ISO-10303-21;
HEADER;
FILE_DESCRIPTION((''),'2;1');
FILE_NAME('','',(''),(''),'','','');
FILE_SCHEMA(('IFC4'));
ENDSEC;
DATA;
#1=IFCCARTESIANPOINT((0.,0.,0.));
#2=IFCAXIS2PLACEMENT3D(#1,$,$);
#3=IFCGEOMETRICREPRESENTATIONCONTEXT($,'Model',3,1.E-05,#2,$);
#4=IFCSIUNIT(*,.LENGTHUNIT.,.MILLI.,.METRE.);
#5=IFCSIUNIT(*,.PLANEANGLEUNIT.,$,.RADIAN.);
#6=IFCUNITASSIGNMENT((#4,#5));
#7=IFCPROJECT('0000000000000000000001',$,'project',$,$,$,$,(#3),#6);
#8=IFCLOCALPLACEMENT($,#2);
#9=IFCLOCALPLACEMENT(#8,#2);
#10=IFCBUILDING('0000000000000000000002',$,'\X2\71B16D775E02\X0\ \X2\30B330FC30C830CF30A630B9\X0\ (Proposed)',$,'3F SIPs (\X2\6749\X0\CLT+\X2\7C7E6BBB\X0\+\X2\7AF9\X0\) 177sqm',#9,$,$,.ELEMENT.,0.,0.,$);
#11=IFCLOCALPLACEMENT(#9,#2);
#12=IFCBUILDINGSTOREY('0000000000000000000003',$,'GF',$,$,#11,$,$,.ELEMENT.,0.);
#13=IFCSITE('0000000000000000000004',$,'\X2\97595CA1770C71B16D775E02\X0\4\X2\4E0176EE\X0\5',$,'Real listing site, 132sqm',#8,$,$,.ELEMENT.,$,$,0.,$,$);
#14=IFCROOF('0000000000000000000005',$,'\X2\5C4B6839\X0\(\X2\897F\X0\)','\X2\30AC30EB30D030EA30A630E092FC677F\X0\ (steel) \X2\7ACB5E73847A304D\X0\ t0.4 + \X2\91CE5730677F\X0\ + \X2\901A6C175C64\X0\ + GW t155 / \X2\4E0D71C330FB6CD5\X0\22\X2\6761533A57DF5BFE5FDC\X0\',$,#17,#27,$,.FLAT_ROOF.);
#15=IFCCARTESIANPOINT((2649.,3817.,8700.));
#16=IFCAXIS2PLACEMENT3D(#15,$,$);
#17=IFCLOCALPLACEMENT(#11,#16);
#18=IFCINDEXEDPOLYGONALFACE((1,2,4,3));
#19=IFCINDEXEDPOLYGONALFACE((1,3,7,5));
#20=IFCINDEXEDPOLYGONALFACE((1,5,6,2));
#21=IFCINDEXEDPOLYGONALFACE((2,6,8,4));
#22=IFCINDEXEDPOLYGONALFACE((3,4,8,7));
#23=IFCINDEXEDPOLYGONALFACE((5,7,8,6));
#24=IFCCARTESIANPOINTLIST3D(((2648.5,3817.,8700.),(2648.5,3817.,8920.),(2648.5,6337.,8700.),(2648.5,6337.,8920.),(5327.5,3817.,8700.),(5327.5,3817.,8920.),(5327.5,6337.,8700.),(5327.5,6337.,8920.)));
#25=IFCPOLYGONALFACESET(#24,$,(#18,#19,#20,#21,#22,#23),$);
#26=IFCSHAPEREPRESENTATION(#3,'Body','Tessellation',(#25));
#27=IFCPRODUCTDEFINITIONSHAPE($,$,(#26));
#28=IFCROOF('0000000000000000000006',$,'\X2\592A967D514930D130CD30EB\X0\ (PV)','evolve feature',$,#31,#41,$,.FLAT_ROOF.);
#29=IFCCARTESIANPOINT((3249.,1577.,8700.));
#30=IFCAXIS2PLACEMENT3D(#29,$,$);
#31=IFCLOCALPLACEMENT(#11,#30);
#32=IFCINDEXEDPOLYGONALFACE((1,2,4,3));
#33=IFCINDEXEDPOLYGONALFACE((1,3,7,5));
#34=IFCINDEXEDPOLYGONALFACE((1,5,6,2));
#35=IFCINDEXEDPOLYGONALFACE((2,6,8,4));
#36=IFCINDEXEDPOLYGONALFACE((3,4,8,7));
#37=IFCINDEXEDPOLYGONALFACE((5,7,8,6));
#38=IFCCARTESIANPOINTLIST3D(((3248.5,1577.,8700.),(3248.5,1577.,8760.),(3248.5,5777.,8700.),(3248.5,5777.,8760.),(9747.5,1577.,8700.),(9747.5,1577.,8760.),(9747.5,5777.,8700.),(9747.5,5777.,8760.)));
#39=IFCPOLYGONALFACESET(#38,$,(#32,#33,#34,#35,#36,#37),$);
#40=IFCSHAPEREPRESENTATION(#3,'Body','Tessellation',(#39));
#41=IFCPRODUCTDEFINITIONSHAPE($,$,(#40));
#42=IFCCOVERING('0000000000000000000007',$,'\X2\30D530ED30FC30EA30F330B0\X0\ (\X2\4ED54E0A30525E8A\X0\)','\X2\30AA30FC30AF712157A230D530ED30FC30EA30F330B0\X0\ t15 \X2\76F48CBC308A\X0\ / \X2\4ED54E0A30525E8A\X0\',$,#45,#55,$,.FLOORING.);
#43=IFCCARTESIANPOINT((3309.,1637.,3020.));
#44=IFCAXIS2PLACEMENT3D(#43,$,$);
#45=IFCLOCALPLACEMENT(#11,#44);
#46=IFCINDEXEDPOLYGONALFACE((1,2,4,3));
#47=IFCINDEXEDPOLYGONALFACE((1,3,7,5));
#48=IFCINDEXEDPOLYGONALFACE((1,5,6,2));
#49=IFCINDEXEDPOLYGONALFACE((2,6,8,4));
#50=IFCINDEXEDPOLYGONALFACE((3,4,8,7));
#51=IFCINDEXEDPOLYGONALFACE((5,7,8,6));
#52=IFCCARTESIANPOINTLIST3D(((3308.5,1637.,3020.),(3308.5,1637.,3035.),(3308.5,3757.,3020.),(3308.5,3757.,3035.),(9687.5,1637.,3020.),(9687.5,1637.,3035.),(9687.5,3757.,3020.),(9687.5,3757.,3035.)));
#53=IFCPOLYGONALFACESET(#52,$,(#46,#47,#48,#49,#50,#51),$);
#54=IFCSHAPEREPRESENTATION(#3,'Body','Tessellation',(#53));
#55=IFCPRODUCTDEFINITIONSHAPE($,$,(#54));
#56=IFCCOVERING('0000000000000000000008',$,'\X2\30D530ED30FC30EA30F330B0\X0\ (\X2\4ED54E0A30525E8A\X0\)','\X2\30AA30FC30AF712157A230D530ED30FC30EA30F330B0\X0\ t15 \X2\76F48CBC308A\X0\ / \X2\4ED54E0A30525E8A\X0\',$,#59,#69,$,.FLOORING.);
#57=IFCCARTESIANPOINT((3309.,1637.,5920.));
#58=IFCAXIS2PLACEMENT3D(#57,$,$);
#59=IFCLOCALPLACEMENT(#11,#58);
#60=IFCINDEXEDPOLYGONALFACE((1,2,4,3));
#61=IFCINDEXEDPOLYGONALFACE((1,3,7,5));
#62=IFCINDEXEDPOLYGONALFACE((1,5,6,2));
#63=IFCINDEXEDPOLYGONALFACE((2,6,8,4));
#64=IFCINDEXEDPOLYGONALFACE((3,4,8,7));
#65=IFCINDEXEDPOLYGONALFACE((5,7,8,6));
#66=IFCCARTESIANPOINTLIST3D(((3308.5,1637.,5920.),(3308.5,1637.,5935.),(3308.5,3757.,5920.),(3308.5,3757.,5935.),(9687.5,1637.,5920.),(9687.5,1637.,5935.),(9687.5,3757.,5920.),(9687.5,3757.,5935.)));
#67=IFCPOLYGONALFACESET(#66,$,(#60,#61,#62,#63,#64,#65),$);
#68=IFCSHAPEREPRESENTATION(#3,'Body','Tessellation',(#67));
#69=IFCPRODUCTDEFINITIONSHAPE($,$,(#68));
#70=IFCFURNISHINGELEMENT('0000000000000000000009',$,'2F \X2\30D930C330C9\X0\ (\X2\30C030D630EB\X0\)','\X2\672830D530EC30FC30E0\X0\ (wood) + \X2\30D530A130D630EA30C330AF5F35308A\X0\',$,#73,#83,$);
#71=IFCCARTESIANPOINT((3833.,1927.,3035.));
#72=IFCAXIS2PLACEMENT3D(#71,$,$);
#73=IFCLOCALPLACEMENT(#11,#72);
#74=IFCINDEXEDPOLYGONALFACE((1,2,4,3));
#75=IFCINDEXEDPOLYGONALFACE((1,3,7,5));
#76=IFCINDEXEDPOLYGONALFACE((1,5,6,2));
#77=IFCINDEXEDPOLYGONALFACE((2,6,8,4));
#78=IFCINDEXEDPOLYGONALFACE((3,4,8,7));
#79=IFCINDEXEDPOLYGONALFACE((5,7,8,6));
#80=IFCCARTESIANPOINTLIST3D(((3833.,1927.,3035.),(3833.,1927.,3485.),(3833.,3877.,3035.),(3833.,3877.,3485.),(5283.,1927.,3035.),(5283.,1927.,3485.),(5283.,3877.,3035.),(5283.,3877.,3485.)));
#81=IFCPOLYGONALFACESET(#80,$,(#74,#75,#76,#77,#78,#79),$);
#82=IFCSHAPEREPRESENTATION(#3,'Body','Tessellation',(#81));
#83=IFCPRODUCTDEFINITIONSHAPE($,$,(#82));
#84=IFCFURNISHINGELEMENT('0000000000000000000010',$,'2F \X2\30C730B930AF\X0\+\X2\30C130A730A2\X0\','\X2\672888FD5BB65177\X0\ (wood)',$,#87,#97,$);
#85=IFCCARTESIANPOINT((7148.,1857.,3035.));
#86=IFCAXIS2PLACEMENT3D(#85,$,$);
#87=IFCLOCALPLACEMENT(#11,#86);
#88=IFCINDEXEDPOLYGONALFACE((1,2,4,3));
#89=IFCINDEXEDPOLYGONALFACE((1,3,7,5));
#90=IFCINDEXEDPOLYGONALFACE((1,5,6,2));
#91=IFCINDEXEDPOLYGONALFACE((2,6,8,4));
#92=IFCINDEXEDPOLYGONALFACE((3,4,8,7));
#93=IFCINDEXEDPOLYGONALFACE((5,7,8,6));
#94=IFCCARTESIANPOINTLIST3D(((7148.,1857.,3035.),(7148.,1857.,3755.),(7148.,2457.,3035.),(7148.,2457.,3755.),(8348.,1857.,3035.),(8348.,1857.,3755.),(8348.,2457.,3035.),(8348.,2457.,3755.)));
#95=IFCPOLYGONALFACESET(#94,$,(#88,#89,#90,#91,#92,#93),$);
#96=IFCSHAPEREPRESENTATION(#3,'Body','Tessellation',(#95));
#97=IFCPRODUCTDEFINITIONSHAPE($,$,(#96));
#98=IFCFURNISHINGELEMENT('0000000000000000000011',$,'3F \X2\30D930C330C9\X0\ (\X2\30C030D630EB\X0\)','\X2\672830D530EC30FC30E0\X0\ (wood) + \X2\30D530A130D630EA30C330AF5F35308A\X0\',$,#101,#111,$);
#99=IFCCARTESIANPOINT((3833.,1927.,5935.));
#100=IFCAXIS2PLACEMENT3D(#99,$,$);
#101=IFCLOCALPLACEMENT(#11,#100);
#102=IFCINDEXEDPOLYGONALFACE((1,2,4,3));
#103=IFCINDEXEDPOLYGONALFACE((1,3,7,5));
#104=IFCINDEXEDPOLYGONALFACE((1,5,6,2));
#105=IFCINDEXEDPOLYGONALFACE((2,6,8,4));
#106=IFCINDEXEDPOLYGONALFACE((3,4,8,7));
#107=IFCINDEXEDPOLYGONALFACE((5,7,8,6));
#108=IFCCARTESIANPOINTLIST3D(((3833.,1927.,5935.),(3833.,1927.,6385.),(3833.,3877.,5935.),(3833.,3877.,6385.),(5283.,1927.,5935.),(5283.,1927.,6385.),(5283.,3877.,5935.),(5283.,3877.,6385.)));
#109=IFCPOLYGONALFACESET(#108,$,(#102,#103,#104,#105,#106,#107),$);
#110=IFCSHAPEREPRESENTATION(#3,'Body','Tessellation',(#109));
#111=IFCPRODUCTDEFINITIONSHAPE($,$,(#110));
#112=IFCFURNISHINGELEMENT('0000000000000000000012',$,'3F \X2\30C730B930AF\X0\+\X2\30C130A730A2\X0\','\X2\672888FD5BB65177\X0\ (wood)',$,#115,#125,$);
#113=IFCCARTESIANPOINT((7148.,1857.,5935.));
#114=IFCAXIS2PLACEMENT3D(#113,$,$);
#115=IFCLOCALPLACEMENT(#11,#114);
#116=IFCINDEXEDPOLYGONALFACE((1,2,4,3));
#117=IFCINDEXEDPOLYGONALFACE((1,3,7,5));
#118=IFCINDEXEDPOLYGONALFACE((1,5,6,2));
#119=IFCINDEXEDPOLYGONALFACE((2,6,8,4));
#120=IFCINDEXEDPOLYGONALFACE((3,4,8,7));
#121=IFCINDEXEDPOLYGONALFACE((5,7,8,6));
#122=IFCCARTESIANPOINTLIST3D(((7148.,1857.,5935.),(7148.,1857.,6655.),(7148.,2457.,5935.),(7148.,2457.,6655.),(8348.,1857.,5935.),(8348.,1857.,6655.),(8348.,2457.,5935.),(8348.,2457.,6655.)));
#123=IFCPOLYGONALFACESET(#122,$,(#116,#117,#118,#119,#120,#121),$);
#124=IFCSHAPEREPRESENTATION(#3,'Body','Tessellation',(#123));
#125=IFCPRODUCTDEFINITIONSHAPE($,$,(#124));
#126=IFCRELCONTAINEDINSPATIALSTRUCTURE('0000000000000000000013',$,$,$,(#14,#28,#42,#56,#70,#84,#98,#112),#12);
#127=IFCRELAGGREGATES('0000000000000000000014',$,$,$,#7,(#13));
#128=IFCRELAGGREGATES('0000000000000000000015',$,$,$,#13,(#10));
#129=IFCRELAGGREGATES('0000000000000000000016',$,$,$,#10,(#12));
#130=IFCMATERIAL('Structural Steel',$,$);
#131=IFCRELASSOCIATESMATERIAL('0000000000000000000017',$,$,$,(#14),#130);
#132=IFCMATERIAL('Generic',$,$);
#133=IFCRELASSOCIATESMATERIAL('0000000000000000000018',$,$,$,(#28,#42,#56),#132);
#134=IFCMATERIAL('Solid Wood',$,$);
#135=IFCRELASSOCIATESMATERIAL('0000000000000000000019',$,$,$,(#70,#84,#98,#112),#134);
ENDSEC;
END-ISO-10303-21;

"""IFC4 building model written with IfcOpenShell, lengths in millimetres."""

from ifc_helpers import new_model, si_unit, frame, frame_2d, origin, place, context, project, spatial, rectangle, extrude, material, element, save


model = new_model("IFC4")

# Units and contexts
model_context = context("Model", 3, precision=1e-05, world=origin())
ifc_project = project(units=[si_unit("LENGTHUNIT", "METRE", prefix="MILLI"), si_unit("PLANEANGLEUNIT", "RADIAN")], contexts=[model_context])

# Site, building, storey
site_placement = place(None, origin())
site = spatial("IfcSite", under=ifc_project, at=site_placement, Name="静岡県熱海市4丁目5", ObjectType="Real listing site, 132sqm", CompositionType="ELEMENT", RefElevation=0.0)
building_placement = place(site_placement, origin())
building = spatial("IfcBuilding", under=site, at=building_placement, Name="熱海市 コートハウス (Proposed)", ObjectType="3F SIPs (杉CLT+籾殻+竹) 177sqm", CompositionType="ELEMENT", ElevationOfRefHeight=0.0, ElevationOfTerrain=0.0)
storey_placement = place(building_placement, origin())
storey = spatial("IfcBuildingStorey", under=building, at=storey_placement, Name="GF", CompositionType="ELEMENT", Elevation=0.0)

# Shared definitions
ifc_material_1 = material(Name="Solid Wood")

# Roofs
ifc_material_2 = material(Name="Structural Steel")
roof_1_placement = place(storey_placement, frame((2649.0, 3817.0, 8700.0)))
element("IfcRoof", 1, at=roof_1_placement, inside=storey, material=ifc_material_2, Name="屋根(西)", Description="ガルバリウム鋼板 (steel) 立平葺き t0.4 + 野地板 + 通気層 + GW t155 / 不燃・法22条区域対応", PredefinedType="FLAT_ROOF", context=model_context, shape_type="SweptSolid", body=[
    extrude(rectangle(XDim=2679.0, YDim=2520.0, at=frame_2d((1339.0, 1260.0))), frame((2649.0, 3817.0, 8700.0)), (0.0, 0.0, 1.0), 220.0),
])
ifc_material_3 = material(Name="Generic")
roof_2_placement = place(storey_placement, frame((3249.0, 1577.0, 8700.0)))
element("IfcRoof", 2, at=roof_2_placement, inside=storey, material=ifc_material_3, Name="太陽光パネル (PV)", Description="evolve feature", PredefinedType="FLAT_ROOF", context=model_context, shape_type="SweptSolid", body=[
    extrude(rectangle(XDim=6499.0, YDim=4200.0, at=frame_2d((3249.0, 2100.0))), frame((3249.0, 1577.0, 8700.0)), (0.0, 0.0, 1.0), 60.0),
])

# Coverings
covering_1_placement = place(storey_placement, frame((3309.0, 1637.0, 3020.0)))
element("IfcCovering", 3, at=covering_1_placement, inside=storey, material=ifc_material_3, Name="フローリング (仕上げ床)", Description="オーク無垢フローリング t15 直貼り / 仕上げ床", PredefinedType="FLOORING", context=model_context, shape_type="SweptSolid", body=[
    extrude(rectangle(XDim=6379.0, YDim=2120.0, at=frame_2d((3189.0, 1060.0))), frame((3309.0, 1637.0, 3020.0)), (0.0, 0.0, 1.0), 15.0),
])
covering_2_placement = place(storey_placement, frame((3309.0, 1637.0, 5920.0)))
element("IfcCovering", 4, at=covering_2_placement, inside=storey, material=ifc_material_3, Name="フローリング (仕上げ床)", Description="オーク無垢フローリング t15 直貼り / 仕上げ床", PredefinedType="FLOORING", context=model_context, shape_type="SweptSolid", body=[
    extrude(rectangle(XDim=6379.0, YDim=2120.0, at=frame_2d((3189.0, 1060.0))), frame((3309.0, 1637.0, 5920.0)), (0.0, 0.0, 1.0), 15.0),
])

# Furnishing elements
furnishing_1_placement = place(storey_placement, frame((3833.0, 1927.0, 3035.0)))
element("IfcFurnishingElement", 5, at=furnishing_1_placement, inside=storey, material=ifc_material_1, Name="2F ベッド (ダブル)", Description="木フレーム (wood) + ファブリック張り", context=model_context, shape_type="SweptSolid", body=[
    extrude(rectangle(XDim=1450.0, YDim=1950.0, at=frame_2d((725.0, 975.0))), frame((3833.0, 1927.0, 3035.0)), (0.0, 0.0, 1.0), 450.0),
])
furnishing_2_placement = place(storey_placement, frame((7148.0, 1857.0, 3035.0)))
element("IfcFurnishingElement", 6, at=furnishing_2_placement, inside=storey, material=ifc_material_1, Name="2F デスク+チェア", Description="木製家具 (wood)", context=model_context, shape_type="SweptSolid", body=[
    extrude(rectangle(XDim=1200.0, YDim=600.0, at=frame_2d((600.0, 300.0))), frame((7148.0, 1857.0, 3035.0)), (0.0, 0.0, 1.0), 720.0),
])
furnishing_3_placement = place(storey_placement, frame((3833.0, 1927.0, 5935.0)))
element("IfcFurnishingElement", 7, at=furnishing_3_placement, inside=storey, material=ifc_material_1, Name="3F ベッド (ダブル)", Description="木フレーム (wood) + ファブリック張り", context=model_context, shape_type="SweptSolid", body=[
    extrude(rectangle(XDim=1450.0, YDim=1950.0, at=frame_2d((725.0, 975.0))), frame((3833.0, 1927.0, 5935.0)), (0.0, 0.0, 1.0), 450.0),
])
furnishing_4_placement = place(storey_placement, frame((7148.0, 1857.0, 5935.0)))
element("IfcFurnishingElement", 8, at=furnishing_4_placement, inside=storey, material=ifc_material_1, Name="3F デスク+チェア", Description="木製家具 (wood)", context=model_context, shape_type="SweptSolid", body=[
    extrude(rectangle(XDim=1200.0, YDim=600.0, at=frame_2d((600.0, 300.0))), frame((7148.0, 1857.0, 5935.0)), (0.0, 0.0, 1.0), 720.0),
])

save(model, "model.ifc")
